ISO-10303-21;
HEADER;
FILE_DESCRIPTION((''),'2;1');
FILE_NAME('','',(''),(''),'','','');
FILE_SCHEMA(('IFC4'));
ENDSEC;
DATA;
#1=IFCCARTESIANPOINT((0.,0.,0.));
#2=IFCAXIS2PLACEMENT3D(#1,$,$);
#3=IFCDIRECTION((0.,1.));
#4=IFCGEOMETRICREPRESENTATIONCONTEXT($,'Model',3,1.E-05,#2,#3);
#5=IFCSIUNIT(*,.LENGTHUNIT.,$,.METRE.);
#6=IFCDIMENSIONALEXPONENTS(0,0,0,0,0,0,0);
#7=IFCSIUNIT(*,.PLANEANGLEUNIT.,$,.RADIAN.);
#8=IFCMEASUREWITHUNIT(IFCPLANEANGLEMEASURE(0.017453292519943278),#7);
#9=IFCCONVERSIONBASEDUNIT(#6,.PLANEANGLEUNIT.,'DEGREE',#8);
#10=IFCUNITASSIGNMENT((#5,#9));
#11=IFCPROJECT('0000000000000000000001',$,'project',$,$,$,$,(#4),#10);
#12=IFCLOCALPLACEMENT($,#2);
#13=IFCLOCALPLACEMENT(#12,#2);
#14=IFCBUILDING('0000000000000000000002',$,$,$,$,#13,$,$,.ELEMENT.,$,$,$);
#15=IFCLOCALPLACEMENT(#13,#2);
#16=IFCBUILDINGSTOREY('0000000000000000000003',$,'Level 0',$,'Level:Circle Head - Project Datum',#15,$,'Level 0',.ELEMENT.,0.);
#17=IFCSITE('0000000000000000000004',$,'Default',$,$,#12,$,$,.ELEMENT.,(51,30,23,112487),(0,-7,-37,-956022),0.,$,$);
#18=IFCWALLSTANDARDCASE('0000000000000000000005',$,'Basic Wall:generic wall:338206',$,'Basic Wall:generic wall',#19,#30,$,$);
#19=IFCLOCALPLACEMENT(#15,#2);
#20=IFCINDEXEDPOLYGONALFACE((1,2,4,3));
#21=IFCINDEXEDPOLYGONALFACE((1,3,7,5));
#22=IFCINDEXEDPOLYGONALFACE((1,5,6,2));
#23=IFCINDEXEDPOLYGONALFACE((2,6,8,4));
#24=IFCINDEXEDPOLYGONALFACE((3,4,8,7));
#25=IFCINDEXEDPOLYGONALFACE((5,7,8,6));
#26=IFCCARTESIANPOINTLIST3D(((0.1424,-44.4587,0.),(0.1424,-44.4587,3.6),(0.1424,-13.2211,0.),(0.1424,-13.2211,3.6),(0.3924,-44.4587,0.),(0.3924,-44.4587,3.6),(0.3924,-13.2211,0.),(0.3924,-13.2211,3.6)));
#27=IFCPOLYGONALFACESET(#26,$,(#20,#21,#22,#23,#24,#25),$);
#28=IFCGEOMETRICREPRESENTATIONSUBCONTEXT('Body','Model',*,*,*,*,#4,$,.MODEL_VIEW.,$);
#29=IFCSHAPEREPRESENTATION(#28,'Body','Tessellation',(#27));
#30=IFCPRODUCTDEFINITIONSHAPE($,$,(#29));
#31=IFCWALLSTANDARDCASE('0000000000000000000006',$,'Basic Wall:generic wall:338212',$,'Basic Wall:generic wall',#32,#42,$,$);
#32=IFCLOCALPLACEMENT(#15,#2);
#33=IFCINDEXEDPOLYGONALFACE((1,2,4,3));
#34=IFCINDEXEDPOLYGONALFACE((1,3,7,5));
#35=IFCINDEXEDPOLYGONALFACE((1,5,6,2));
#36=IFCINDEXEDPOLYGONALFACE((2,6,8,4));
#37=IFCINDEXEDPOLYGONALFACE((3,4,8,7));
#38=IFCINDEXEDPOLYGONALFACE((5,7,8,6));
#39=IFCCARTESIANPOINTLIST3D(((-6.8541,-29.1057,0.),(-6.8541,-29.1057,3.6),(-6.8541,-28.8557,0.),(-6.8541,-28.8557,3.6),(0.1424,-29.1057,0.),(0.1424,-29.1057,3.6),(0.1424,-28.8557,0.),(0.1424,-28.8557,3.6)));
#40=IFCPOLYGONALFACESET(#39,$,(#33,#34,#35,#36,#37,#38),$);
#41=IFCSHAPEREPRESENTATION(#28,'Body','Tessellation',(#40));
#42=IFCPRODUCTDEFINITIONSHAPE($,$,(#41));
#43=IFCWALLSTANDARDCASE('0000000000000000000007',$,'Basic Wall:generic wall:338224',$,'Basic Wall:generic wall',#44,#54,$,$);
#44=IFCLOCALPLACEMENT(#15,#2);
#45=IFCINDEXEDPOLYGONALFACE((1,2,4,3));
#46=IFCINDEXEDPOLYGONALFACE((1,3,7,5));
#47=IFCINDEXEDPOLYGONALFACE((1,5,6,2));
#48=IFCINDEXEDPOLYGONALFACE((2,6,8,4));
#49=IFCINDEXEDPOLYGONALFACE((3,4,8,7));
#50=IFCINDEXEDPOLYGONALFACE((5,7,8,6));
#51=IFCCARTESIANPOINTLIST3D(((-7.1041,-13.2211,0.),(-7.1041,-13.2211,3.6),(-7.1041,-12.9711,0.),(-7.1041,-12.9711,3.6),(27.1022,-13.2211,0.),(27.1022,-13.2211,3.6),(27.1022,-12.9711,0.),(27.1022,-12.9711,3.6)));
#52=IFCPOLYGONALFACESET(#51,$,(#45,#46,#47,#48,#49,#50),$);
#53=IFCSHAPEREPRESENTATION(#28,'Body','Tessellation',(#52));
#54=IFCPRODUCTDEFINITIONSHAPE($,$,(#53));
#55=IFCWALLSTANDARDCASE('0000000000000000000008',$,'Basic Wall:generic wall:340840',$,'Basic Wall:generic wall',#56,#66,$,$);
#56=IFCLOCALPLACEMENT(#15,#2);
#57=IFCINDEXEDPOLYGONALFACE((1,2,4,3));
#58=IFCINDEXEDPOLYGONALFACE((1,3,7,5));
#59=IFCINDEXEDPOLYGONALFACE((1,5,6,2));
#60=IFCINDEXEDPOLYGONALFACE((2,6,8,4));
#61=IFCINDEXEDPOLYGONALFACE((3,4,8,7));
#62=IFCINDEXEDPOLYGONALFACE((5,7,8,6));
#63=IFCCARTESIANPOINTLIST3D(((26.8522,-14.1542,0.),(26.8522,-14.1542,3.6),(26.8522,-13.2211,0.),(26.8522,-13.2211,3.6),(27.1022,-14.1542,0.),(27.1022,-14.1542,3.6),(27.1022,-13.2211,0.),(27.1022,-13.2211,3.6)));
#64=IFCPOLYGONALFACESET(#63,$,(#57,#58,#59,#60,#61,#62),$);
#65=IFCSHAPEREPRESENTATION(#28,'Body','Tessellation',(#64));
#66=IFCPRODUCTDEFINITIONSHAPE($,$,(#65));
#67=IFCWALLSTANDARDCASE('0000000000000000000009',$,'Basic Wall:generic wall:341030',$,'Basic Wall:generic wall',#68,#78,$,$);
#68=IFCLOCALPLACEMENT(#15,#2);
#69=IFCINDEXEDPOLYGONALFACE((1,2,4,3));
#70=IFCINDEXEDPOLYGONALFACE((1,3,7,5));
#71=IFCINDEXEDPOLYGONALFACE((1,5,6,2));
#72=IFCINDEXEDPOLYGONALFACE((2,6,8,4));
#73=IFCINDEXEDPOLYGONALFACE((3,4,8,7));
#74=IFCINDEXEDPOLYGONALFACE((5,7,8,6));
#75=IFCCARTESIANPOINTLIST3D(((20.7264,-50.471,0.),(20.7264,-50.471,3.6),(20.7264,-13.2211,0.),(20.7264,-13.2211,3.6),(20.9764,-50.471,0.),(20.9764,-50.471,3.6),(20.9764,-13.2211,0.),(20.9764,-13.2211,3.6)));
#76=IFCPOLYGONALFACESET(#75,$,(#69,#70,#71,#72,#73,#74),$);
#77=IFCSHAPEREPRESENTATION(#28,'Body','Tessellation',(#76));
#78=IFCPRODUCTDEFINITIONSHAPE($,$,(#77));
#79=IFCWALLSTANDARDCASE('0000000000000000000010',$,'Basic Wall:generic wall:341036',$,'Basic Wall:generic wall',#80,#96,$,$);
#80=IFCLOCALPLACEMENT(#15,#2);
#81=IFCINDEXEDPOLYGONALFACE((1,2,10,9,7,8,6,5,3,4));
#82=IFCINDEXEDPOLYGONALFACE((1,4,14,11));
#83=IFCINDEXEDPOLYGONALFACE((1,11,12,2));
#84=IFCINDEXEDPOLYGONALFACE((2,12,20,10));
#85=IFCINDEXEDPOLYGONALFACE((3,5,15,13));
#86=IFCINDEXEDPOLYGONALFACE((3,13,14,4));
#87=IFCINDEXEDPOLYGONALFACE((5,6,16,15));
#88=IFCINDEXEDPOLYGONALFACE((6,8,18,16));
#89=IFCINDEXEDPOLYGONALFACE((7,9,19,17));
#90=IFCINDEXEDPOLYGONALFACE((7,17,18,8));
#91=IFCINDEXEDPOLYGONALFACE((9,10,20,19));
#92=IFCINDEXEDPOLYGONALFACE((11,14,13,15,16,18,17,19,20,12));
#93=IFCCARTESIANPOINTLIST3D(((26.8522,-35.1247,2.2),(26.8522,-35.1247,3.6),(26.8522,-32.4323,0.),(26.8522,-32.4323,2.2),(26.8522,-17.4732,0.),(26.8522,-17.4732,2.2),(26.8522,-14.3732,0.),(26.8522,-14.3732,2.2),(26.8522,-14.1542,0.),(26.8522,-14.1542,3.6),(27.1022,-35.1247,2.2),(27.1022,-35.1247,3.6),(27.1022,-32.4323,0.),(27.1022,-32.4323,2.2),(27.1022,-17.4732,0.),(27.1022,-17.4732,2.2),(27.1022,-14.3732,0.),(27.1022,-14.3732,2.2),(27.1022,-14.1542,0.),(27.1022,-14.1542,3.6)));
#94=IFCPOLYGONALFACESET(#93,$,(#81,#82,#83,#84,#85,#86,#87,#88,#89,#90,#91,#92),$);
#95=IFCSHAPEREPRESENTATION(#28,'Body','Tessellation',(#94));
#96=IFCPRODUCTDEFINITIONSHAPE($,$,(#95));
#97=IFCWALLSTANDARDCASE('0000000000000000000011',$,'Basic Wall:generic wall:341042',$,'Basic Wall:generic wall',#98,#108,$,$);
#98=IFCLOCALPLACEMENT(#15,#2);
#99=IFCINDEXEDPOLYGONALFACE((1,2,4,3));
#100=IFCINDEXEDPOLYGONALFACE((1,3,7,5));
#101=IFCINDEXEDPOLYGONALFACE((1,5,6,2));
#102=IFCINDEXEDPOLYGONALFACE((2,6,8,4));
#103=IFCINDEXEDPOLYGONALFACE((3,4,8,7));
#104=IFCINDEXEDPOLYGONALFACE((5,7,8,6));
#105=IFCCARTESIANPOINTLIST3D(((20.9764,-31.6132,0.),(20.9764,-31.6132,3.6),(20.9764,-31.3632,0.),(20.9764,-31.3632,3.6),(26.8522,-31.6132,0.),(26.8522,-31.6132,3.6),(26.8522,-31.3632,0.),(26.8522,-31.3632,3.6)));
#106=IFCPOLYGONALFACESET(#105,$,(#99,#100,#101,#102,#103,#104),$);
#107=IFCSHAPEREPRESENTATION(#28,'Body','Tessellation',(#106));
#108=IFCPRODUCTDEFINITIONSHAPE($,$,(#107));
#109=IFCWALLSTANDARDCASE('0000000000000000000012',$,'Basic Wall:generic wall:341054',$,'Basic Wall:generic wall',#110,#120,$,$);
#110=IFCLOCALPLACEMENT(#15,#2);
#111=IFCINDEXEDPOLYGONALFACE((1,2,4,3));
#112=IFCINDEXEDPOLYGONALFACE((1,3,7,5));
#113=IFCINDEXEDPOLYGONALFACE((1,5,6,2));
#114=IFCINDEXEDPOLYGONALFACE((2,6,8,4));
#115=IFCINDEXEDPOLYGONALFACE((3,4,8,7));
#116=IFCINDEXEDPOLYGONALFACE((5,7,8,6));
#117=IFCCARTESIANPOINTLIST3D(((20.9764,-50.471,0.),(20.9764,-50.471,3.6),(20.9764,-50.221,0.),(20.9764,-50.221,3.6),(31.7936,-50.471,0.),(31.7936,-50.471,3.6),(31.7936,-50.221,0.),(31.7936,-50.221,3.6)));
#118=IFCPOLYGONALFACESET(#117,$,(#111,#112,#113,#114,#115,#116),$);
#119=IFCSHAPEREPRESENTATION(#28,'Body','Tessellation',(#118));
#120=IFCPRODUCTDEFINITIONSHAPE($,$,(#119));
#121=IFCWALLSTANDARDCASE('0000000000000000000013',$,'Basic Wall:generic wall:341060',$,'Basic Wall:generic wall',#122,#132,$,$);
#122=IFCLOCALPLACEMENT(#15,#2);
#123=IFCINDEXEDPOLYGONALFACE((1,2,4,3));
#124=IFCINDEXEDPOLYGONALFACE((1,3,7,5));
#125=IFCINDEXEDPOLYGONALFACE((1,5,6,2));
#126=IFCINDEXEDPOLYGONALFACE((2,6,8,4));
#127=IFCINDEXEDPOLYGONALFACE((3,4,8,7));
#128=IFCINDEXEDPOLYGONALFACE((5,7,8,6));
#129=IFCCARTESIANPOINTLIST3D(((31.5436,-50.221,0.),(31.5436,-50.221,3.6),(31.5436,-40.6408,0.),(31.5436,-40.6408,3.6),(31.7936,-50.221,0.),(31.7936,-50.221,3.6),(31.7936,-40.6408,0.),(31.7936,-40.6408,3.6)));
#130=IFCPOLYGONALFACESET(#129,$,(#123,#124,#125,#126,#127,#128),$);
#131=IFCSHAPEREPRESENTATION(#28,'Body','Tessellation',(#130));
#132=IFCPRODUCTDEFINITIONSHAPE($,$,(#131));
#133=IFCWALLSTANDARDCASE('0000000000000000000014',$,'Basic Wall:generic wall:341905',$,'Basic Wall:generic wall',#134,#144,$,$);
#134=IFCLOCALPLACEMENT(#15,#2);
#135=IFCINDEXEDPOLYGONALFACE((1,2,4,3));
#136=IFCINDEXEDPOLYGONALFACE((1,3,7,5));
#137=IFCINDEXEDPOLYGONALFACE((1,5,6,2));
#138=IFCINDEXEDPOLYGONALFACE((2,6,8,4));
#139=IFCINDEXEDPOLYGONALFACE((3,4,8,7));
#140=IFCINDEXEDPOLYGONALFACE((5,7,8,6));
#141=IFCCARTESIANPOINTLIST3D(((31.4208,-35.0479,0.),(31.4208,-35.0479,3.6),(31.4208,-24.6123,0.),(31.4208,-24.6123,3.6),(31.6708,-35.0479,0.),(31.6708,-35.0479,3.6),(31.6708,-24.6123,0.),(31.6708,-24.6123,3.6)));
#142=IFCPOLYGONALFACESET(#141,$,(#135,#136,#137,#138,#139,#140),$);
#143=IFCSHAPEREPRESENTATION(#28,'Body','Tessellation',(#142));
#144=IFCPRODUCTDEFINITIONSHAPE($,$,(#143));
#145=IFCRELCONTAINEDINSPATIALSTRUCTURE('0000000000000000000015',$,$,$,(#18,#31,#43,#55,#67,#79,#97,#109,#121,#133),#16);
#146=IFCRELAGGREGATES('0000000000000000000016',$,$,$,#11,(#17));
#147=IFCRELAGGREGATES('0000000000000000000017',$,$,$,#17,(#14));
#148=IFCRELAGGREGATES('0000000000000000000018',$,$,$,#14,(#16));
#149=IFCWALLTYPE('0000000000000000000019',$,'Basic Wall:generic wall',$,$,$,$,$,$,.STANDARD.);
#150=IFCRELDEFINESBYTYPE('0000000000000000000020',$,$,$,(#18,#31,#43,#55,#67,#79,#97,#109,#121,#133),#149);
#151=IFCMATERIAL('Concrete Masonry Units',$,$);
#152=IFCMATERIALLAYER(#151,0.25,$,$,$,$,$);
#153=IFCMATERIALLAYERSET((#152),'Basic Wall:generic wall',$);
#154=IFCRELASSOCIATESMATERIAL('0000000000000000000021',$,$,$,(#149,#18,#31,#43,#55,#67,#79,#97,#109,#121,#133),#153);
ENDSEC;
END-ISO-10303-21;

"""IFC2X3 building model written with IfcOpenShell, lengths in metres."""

from ifc_helpers import new_model, entity, si_unit, converted_unit, direction, frame, frame_2d, origin, place, context, subcontext, project, spatial, rectangle, extrude, material, layer, layer_set, layer_usage, type_object, element, save


model = new_model("IFC2X3")

# Units and contexts
model_context = context("Model", 3, precision=1e-05, world=origin(), true_north=direction((0.0, 1.0)))
body_context = subcontext(model_context, "Body", "Model", "MODEL_VIEW")
ifc_project = project(units=[si_unit("LENGTHUNIT", "METRE"), converted_unit("PLANEANGLEUNIT", "DEGREE", entity("IfcPlaneAngleMeasure", 0.017453292519943278), si_unit("PLANEANGLEUNIT", "RADIAN"), dimensions=[0, 0, 0, 0, 0, 0, 0])], contexts=[model_context])

# Site, building, storey
site_placement = place(None, origin())
site = spatial("IfcSite", under=ifc_project, at=site_placement, Name="Default", CompositionType="ELEMENT", RefLatitude=(51, 30, 23, 112487), RefLongitude=(0, -7, -37, -956022), RefElevation=0.0)
building_placement = place(site_placement, origin())
building = spatial("IfcBuilding", under=site, at=building_placement, CompositionType="ELEMENT")
storey_placement = place(building_placement, origin())
storey = spatial("IfcBuildingStorey", under=building, at=storey_placement, Name="Level 0", ObjectType="Level:Circle Head - Project Datum", LongName="Level 0", CompositionType="ELEMENT", Elevation=0.0)

# Walls
ifc_material = material(Name="Concrete Masonry Units")
ifc_layer = layer(ifc_material, 0.25)
ifc_layer_set = layer_set([ifc_layer], Name="Basic Wall:generic wall")
ifc_layer_usage_1 = layer_usage(ifc_layer_set, "AXIS2", "NEGATIVE", 0.125)
wall_type = type_object("IfcWallType", Name="Basic Wall:generic wall", PredefinedType="STANDARD", material=ifc_layer_set)
wall_1_placement = place(storey_placement, frame((0.2674, -44.4587, 0.0), z_axis=(0.0, 0.0, 1.0), x_axis=(0.0, 1.0, 0.0)))
element("IfcWallStandardCase", 1, at=wall_1_placement, inside=storey, type_object=wall_type, material=ifc_layer_usage_1, Name="Basic Wall:generic wall:338206", ObjectType="Basic Wall:generic wall", context=body_context, shape_type="SweptSolid", body=[
    extrude(rectangle(XDim=31.2376, YDim=0.25, at=frame_2d((15.6188, 0.0), x_axis=(-1.0, 0.0))), origin(), (0.0, 0.0, 1.0), 3.6),
])
ifc_layer_usage_2 = layer_usage(ifc_layer_set, "AXIS2", "NEGATIVE", 0.125)
wall_2_placement = place(storey_placement, frame((0.1424, -28.9807, 0.0), z_axis=(0.0, 0.0, 1.0), x_axis=(-1.0, 0.0, 0.0)))
element("IfcWallStandardCase", 2, at=wall_2_placement, inside=storey, type_object=wall_type, material=ifc_layer_usage_2, Name="Basic Wall:generic wall:338212", ObjectType="Basic Wall:generic wall", context=body_context, shape_type="SweptSolid", body=[
    extrude(rectangle(XDim=6.9966, YDim=0.25, at=frame_2d((3.4983, 0.0), x_axis=(-1.0, 0.0))), origin(), (0.0, 0.0, 1.0), 3.6),
])
ifc_layer_usage_3 = layer_usage(ifc_layer_set, "AXIS2", "NEGATIVE", 0.125)
wall_3_placement = place(storey_placement, frame((27.1022, -13.0961, 0.0), z_axis=(0.0, 0.0, 1.0), x_axis=(-1.0, 0.0, 0.0)))
element("IfcWallStandardCase", 3, at=wall_3_placement, inside=storey, type_object=wall_type, material=ifc_layer_usage_3, Name="Basic Wall:generic wall:338224", ObjectType="Basic Wall:generic wall", context=body_context, shape_type="SweptSolid", body=[
    extrude(rectangle(XDim=34.2063, YDim=0.25, at=frame_2d((17.1032, 0.0), x_axis=(-1.0, 0.0))), origin(), (0.0, 0.0, 1.0), 3.6),
])
ifc_layer_usage_4 = layer_usage(ifc_layer_set, "AXIS2", "NEGATIVE", 0.125)
wall_4_placement = place(storey_placement, frame((26.9772, -13.2211, 0.0), z_axis=(0.0, 0.0, 1.0), x_axis=(0.0, -1.0, 0.0)))
element("IfcWallStandardCase", 4, at=wall_4_placement, inside=storey, type_object=wall_type, material=ifc_layer_usage_4, Name="Basic Wall:generic wall:340840", ObjectType="Basic Wall:generic wall", context=body_context, shape_type="SweptSolid", body=[
    extrude(rectangle(XDim=0.9331, YDim=0.25, at=frame_2d((0.4665, 0.0), x_axis=(-1.0, 0.0))), origin(), (0.0, 0.0, 1.0), 3.6),
])
ifc_layer_usage_5 = layer_usage(ifc_layer_set, "AXIS2", "NEGATIVE", 0.125)
wall_5_placement = place(storey_placement, frame((20.8514, -13.2211, 0.0), z_axis=(0.0, 0.0, 1.0), x_axis=(0.0, -1.0, 0.0)))
element("IfcWallStandardCase", 5, at=wall_5_placement, inside=storey, type_object=wall_type, material=ifc_layer_usage_5, Name="Basic Wall:generic wall:341030", ObjectType="Basic Wall:generic wall", context=body_context, shape_type="SweptSolid", body=[
    extrude(rectangle(XDim=37.2499, YDim=0.25, at=frame_2d((18.6249, 0.0), x_axis=(-1.0, 0.0))), origin(), (0.0, 0.0, 1.0), 3.6),
])

# Wall, openings
ifc_layer_usage_6 = layer_usage(ifc_layer_set, "AXIS2", "NEGATIVE", 0.125)
wall_6_placement = place(storey_placement, frame((26.9772, -14.1542, 0.0), z_axis=(0.0, 0.0, 1.0), x_axis=(0.0, -1.0, 0.0)))
wall_6 = element("IfcWallStandardCase", 6, at=wall_6_placement, inside=storey, type_object=wall_type, material=ifc_layer_usage_6, Name="Basic Wall:generic wall:341036", ObjectType="Basic Wall:generic wall", context=body_context, shape_type="SweptSolid", body=[
    extrude(rectangle(XDim=20.9705, YDim=0.25, at=frame_2d((10.4852, 0.0), x_axis=(-1.0, 0.0))), origin(), (0.0, 0.0, 1.0), 3.6),
])
opening_1_placement = place(wall_6_placement, frame((21.3781, 0.125, 0.0)))
element("IfcOpeningElement", 7, at=opening_1_placement, cuts=wall_6, ObjectType="Opening", context=body_context, shape_type="SweptSolid", body=[
    extrude(rectangle(XDim=2.2, YDim=3.1, at=frame_2d((1.1, 1.55), x_axis=(1.0, 0.0))), frame((0.0, 0.0, 0.0), z_axis=(0.0, -1.0, 0.0), x_axis=(0.0, 0.0, 1.0)), (0.0, 0.0, 1.0), 0.25),
])
opening_2_placement = place(wall_6_placement, frame((3.3191, 0.125, 0.0)))
element("IfcOpeningElement", 8, at=opening_2_placement, cuts=wall_6, ObjectType="Opening", context=body_context, shape_type="SweptSolid", body=[
    extrude(rectangle(XDim=2.2, YDim=3.1, at=frame_2d((1.1, 1.55), x_axis=(1.0, 0.0))), frame((0.0, 0.0, 0.0), z_axis=(0.0, -1.0, 0.0), x_axis=(0.0, 0.0, 1.0)), (0.0, 0.0, 1.0), 0.25),
])

# Wall
ifc_layer_usage_7 = layer_usage(ifc_layer_set, "AXIS2", "NEGATIVE", 0.125)
wall_7_placement = place(storey_placement, frame((26.8522, -31.4882, 0.0), z_axis=(0.0, 0.0, 1.0), x_axis=(-1.0, 0.0, 0.0)))
element("IfcWallStandardCase", 9, at=wall_7_placement, inside=storey, type_object=wall_type, material=ifc_layer_usage_7, Name="Basic Wall:generic wall:341042", ObjectType="Basic Wall:generic wall", context=body_context, shape_type="SweptSolid", body=[
    extrude(rectangle(XDim=5.8758, YDim=0.25, at=frame_2d((2.9379, 0.0), x_axis=(-1.0, 0.0))), origin(), (0.0, 0.0, 1.0), 3.6),
])

# Walls
ifc_layer_usage_8 = layer_usage(ifc_layer_set, "AXIS2", "NEGATIVE", 0.125)
wall_8_placement = place(storey_placement, frame((20.9764, -50.346, 0.0)))
element("IfcWallStandardCase", 10, at=wall_8_placement, inside=storey, type_object=wall_type, material=ifc_layer_usage_8, Name="Basic Wall:generic wall:341054", ObjectType="Basic Wall:generic wall", context=body_context, shape_type="SweptSolid", body=[
    extrude(rectangle(XDim=10.8172, YDim=0.25, at=frame_2d((5.4086, 0.0), x_axis=(-1.0, 0.0))), origin(), (0.0, 0.0, 1.0), 3.6),
])
ifc_layer_usage_9 = layer_usage(ifc_layer_set, "AXIS2", "NEGATIVE", 0.125)
wall_9_placement = place(storey_placement, frame((31.6686, -50.221, 0.0), z_axis=(0.0, 0.0, 1.0), x_axis=(0.0, 1.0, 0.0)))
element("IfcWallStandardCase", 11, at=wall_9_placement, inside=storey, type_object=wall_type, material=ifc_layer_usage_9, Name="Basic Wall:generic wall:341060", ObjectType="Basic Wall:generic wall", context=body_context, shape_type="SweptSolid", body=[
    extrude(rectangle(XDim=9.5802, YDim=0.25, at=frame_2d((4.7901, 0.0), x_axis=(-1.0, 0.0))), origin(), (0.0, 0.0, 1.0), 3.6),
])
ifc_layer_usage_10 = layer_usage(ifc_layer_set, "AXIS2", "NEGATIVE", 0.125)
wall_10_placement = place(storey_placement, frame((31.5458, -35.0479, 0.0), z_axis=(0.0, 0.0, 1.0), x_axis=(0.0, 1.0, 0.0)))
element("IfcWallStandardCase", 12, at=wall_10_placement, inside=storey, type_object=wall_type, material=ifc_layer_usage_10, Name="Basic Wall:generic wall:341905", ObjectType="Basic Wall:generic wall", context=body_context, shape_type="SweptSolid", body=[
    extrude(rectangle(XDim=10.4356, YDim=0.25, at=frame_2d((5.2178, 0.0), x_axis=(-1.0, 0.0))), origin(), (0.0, 0.0, 1.0), 3.6),
])

save(model, "model.ifc")
